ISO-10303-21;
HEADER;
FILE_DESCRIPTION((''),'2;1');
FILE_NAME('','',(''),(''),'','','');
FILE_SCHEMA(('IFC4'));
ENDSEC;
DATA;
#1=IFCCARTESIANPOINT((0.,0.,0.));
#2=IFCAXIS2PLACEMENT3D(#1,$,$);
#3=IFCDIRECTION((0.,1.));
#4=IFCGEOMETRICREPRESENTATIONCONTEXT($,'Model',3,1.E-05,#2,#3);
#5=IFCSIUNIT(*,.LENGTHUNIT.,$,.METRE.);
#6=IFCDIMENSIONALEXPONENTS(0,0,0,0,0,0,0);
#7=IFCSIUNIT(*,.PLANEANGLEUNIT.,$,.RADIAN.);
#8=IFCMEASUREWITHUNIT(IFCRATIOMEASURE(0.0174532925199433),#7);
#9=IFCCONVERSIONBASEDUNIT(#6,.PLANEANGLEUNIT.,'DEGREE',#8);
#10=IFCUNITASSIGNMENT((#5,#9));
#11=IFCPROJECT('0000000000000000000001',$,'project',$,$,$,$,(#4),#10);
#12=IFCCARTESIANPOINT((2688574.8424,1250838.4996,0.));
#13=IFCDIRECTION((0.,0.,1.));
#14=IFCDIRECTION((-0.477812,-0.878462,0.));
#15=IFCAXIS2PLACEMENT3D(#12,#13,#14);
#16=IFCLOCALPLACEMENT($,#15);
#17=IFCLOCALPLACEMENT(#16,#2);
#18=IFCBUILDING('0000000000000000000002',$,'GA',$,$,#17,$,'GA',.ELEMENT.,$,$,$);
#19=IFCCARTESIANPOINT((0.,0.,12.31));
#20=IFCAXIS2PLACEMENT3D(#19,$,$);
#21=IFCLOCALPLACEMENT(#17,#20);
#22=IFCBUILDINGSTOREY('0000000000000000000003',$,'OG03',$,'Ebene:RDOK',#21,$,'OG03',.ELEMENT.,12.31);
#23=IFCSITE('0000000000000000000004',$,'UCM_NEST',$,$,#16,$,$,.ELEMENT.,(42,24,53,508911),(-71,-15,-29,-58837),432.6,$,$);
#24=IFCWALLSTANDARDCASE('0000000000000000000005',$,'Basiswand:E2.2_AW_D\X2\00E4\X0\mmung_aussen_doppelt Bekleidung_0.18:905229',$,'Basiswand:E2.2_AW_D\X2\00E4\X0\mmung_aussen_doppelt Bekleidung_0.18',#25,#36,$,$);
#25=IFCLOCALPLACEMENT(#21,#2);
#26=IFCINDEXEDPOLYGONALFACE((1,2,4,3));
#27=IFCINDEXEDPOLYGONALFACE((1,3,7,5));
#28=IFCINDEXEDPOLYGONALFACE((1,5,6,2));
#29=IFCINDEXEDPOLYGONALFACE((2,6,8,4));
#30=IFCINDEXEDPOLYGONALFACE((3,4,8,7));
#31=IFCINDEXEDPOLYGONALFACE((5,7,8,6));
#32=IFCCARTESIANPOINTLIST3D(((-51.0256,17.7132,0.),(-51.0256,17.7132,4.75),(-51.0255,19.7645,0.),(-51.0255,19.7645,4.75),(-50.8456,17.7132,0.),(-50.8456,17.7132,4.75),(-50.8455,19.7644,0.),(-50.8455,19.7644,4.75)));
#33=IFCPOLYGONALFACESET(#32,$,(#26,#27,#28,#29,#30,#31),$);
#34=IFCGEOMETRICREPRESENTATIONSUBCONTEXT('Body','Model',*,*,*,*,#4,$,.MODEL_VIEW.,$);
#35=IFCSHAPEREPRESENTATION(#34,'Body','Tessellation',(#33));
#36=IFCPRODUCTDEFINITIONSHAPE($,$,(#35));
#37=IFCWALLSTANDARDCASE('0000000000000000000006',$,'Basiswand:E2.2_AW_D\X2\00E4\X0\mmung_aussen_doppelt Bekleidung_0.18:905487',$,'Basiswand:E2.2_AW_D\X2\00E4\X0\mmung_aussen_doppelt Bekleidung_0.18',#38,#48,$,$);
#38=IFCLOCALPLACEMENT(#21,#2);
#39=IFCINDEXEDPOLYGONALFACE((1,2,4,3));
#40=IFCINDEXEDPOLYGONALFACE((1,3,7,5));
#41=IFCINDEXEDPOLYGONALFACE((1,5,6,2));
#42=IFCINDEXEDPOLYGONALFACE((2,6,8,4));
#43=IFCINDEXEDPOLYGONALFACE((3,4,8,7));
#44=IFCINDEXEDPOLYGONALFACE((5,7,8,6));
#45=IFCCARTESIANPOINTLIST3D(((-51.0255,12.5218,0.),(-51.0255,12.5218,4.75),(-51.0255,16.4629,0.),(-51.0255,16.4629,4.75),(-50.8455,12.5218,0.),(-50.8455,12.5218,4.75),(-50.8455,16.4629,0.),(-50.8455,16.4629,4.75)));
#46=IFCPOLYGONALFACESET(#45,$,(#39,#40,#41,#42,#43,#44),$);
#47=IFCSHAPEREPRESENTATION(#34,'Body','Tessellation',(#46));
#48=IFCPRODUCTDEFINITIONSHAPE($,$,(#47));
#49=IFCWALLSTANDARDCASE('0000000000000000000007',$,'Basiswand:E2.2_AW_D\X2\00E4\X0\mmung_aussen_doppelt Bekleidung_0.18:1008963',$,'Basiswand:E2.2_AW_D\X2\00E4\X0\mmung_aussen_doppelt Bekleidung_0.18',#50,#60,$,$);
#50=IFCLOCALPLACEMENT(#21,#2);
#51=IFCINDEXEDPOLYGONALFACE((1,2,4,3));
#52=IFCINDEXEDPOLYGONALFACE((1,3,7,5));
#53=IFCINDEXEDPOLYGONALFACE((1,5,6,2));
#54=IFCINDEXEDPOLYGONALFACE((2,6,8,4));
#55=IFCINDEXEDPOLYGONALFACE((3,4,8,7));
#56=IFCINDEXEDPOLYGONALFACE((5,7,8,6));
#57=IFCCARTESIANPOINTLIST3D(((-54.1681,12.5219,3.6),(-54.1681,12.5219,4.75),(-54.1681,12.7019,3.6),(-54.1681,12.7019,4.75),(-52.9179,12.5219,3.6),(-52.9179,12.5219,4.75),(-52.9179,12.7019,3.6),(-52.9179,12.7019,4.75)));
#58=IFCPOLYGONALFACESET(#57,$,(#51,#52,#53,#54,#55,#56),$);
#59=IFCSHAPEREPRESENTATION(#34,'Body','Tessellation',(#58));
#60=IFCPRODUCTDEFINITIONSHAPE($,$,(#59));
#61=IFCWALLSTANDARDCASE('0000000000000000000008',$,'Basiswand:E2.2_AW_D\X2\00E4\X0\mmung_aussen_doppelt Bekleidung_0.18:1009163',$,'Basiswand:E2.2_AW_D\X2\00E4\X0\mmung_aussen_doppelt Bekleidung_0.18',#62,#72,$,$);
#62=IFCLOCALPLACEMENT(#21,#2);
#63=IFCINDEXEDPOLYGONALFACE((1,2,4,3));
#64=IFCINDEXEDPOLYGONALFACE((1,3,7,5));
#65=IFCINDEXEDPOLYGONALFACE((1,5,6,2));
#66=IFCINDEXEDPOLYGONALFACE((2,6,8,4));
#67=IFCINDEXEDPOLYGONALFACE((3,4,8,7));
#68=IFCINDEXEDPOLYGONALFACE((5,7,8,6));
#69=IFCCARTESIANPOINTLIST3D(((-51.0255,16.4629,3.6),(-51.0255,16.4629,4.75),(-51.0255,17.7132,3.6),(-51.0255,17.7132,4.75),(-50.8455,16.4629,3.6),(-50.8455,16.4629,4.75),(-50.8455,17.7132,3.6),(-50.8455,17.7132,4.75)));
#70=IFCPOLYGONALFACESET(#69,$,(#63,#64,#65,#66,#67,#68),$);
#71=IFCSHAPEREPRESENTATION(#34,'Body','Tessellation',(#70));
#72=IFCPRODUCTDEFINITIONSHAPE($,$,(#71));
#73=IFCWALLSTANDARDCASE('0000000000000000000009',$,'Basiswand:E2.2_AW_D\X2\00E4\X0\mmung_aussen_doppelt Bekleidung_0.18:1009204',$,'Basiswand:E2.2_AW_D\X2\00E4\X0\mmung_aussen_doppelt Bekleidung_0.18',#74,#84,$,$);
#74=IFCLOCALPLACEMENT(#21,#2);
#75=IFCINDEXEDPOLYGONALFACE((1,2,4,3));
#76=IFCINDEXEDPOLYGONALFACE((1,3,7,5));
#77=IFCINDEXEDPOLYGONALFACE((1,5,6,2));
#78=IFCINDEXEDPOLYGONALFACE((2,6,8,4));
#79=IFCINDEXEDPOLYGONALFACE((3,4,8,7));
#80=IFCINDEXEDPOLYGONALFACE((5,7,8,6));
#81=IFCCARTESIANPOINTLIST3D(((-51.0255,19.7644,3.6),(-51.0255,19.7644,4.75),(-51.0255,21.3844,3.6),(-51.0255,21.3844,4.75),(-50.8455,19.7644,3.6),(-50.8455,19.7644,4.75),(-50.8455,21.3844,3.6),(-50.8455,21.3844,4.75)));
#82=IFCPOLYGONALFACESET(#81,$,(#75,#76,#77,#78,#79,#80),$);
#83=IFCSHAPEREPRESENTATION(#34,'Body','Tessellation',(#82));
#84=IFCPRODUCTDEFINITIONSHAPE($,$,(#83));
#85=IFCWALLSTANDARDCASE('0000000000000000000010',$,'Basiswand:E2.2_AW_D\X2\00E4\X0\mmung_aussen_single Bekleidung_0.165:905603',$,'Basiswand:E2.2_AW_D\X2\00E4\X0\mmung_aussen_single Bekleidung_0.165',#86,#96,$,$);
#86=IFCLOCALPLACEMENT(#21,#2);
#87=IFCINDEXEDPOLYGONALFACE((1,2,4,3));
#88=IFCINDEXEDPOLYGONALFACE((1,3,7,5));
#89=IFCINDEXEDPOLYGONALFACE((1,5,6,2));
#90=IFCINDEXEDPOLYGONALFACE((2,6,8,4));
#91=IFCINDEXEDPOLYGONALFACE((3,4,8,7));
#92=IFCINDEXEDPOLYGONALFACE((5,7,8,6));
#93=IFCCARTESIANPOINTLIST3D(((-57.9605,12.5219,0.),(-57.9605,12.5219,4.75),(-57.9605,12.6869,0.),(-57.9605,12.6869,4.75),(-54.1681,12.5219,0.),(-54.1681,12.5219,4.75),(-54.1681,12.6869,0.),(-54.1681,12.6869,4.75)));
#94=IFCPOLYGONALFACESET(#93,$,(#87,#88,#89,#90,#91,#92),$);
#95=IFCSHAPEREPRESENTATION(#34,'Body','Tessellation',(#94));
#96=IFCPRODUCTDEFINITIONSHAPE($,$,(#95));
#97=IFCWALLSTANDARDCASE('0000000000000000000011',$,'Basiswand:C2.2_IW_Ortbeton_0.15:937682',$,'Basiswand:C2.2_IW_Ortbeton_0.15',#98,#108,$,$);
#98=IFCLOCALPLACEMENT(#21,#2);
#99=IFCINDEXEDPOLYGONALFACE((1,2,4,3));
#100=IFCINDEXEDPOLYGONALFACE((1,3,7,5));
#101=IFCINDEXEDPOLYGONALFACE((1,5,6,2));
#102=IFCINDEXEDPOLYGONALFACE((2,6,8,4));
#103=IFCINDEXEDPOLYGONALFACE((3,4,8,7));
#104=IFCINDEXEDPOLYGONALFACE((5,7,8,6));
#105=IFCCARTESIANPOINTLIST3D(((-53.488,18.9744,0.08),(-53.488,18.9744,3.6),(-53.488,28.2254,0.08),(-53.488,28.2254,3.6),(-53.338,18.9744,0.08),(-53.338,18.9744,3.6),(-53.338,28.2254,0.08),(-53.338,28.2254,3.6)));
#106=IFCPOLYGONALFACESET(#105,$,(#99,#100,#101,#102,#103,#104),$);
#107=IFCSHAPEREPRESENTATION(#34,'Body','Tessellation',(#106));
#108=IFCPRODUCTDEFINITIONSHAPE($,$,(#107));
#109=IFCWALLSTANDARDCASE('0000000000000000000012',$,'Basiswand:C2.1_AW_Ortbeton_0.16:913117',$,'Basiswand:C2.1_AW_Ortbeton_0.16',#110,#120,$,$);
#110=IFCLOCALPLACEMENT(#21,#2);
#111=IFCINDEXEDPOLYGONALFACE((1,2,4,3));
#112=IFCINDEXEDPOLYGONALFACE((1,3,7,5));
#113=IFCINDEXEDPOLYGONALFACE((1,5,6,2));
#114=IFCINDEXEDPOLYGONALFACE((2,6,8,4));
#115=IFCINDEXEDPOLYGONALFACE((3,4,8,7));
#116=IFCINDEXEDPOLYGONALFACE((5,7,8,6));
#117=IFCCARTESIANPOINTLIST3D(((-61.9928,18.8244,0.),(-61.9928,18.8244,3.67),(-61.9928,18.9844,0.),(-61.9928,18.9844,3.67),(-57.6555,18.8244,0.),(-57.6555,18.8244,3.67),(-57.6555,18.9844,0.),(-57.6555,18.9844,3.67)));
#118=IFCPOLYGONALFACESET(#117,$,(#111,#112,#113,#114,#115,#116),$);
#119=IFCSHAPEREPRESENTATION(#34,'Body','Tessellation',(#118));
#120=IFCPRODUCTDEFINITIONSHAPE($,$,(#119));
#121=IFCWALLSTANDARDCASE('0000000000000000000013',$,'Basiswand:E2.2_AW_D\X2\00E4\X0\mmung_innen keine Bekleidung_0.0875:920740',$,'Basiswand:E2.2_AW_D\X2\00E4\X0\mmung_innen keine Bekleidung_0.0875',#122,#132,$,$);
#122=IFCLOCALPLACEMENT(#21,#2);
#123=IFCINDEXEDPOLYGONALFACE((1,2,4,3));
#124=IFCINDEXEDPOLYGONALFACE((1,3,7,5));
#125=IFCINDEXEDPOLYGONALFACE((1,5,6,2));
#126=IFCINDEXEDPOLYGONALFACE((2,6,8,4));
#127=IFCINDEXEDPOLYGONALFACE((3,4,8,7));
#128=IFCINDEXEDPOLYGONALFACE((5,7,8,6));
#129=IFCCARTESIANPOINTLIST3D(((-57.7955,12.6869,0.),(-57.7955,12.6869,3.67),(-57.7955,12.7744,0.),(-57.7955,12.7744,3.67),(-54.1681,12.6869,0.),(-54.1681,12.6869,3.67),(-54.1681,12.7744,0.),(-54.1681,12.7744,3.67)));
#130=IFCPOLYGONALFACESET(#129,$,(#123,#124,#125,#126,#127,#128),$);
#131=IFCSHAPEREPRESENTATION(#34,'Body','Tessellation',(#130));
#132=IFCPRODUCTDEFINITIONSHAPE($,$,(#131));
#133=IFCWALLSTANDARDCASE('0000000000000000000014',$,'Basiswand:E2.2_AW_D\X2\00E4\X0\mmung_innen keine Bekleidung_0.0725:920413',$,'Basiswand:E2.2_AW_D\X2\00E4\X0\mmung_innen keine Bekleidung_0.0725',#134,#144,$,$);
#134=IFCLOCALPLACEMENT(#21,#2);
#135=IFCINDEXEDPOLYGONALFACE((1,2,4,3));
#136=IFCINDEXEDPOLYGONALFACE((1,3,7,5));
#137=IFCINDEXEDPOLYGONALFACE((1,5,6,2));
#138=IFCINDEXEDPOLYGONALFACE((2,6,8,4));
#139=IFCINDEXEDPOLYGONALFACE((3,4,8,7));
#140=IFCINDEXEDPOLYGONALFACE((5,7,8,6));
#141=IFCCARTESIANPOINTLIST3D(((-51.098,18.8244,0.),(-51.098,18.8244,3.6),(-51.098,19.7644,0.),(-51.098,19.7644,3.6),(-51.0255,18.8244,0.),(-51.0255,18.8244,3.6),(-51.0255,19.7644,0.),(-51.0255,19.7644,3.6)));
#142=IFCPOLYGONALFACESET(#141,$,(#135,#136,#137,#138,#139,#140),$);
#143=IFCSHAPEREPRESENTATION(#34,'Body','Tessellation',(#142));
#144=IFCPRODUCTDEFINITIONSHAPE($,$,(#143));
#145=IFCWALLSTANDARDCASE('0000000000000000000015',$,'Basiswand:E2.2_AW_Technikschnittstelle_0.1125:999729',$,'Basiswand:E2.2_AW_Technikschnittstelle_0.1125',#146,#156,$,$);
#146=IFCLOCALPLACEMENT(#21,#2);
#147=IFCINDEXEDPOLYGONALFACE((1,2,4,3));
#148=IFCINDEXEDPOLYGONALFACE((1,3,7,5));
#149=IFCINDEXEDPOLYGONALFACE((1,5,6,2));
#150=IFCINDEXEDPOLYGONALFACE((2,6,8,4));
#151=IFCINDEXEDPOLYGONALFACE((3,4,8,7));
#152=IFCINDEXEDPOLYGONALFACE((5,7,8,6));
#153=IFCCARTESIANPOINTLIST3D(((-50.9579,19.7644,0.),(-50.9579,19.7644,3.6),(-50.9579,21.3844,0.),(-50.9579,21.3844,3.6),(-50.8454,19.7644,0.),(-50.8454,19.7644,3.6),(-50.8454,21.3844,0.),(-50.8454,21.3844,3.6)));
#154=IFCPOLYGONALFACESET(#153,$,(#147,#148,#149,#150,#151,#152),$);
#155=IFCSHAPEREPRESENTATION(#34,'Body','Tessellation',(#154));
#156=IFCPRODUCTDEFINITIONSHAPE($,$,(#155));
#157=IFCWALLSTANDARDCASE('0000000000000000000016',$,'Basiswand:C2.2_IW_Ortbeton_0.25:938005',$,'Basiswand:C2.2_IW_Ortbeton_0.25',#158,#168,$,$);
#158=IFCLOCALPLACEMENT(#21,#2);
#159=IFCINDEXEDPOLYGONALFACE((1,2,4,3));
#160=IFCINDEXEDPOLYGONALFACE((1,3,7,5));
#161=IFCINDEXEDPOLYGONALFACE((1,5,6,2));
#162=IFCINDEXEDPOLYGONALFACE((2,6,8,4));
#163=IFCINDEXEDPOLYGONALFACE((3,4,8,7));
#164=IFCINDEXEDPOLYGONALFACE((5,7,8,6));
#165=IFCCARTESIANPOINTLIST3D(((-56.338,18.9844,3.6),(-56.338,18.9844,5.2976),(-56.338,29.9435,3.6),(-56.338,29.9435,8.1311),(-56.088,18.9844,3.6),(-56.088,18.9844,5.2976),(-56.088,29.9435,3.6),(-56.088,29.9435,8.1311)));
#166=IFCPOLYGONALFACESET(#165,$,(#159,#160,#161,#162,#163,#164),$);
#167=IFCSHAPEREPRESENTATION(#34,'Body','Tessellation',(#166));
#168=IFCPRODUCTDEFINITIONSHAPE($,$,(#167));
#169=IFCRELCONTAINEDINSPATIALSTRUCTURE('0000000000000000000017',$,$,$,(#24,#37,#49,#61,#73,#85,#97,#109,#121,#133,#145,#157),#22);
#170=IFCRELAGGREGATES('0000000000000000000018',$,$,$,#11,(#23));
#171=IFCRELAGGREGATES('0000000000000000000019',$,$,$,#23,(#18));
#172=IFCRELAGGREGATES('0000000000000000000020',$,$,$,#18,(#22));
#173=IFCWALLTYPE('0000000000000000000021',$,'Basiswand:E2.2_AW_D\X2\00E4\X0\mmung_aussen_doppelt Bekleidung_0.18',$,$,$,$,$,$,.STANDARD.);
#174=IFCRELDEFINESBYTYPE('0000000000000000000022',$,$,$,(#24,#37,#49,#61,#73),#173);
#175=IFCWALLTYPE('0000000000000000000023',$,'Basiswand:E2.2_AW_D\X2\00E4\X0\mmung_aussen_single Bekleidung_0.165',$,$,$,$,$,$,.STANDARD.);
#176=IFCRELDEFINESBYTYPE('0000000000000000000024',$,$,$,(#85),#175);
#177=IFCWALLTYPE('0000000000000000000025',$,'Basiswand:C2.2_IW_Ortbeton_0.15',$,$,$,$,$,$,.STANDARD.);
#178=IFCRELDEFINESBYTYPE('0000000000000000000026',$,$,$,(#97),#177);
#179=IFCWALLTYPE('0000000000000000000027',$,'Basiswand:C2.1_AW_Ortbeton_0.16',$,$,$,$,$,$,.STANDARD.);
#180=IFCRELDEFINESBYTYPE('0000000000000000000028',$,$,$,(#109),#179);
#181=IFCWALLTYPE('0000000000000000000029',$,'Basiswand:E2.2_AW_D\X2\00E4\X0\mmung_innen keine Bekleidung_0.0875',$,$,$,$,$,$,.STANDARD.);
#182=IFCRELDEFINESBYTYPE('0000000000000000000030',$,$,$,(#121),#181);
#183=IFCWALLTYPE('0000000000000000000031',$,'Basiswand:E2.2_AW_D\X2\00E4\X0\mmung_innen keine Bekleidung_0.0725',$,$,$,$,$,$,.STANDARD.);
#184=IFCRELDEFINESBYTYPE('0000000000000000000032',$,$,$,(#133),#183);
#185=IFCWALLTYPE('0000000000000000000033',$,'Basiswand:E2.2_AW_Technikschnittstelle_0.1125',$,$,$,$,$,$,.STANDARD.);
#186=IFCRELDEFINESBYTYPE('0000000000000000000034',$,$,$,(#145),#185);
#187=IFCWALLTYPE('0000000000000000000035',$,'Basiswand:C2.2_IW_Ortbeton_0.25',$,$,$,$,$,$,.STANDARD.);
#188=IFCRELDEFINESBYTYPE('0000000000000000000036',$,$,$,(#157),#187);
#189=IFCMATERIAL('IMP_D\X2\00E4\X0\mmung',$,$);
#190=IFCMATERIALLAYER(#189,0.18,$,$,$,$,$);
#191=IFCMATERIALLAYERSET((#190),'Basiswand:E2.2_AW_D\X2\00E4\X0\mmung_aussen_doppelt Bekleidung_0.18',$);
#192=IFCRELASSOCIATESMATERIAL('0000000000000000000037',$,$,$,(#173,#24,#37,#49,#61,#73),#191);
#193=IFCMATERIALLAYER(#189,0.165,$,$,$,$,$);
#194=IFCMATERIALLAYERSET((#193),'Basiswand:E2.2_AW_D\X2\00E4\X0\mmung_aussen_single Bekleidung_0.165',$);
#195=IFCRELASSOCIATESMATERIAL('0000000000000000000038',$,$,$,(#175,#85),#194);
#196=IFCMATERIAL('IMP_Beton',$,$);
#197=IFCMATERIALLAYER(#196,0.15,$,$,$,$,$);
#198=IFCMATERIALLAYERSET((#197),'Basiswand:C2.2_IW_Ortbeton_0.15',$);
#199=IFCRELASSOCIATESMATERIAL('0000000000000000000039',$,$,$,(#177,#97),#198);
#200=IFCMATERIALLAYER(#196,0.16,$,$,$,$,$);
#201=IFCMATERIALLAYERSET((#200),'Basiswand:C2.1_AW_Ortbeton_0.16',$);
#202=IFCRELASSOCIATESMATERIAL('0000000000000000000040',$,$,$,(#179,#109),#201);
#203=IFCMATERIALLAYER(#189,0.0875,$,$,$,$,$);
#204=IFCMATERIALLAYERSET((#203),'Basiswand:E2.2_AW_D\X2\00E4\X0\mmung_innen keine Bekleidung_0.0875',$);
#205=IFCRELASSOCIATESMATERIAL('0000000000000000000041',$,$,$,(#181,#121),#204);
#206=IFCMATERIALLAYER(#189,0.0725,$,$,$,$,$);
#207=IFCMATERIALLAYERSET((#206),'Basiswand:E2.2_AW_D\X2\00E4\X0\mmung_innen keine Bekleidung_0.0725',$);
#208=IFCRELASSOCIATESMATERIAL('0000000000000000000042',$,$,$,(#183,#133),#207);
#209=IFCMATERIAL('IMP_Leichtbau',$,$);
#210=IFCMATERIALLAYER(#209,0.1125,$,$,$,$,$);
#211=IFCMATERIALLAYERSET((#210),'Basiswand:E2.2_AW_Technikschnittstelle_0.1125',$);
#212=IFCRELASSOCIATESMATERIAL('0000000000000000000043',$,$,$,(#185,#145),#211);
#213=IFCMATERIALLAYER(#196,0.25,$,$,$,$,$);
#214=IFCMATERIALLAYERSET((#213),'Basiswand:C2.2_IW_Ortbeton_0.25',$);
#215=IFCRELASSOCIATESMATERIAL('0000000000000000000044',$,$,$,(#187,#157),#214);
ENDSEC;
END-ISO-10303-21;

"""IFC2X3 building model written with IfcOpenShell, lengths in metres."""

from ifc_helpers import new_model, entity, si_unit, converted_unit, direction, frame, frame_2d, origin, place, context, subcontext, project, spatial, polyline, rectangle, extrude, clip, halfspace, bounded_halfspace, material, layer, layer_set, layer_usage, type_object, element, save


model = new_model("IFC2X3")

# Units and contexts
model_context = context("Model", 3, precision=1e-05, world=origin(), true_north=direction((0.0, 1.0)))
body_context = subcontext(model_context, "Body", "Model", "MODEL_VIEW")
ifc_project = project(units=[si_unit("LENGTHUNIT", "METRE"), converted_unit("PLANEANGLEUNIT", "DEGREE", entity("IfcRatioMeasure", 0.0174532925199433), si_unit("PLANEANGLEUNIT", "RADIAN"), dimensions=[0, 0, 0, 0, 0, 0, 0])], contexts=[model_context])

# Site, building, storey
site_placement = place(None, frame((2688574.8424, 1250838.4996, 0.0), z_axis=(0.0, 0.0, 1.0), x_axis=(-0.477812, -0.878462, 0.0)))
site = spatial("IfcSite", under=ifc_project, at=site_placement, Name="UCM_NEST", CompositionType="ELEMENT", RefLatitude=(42, 24, 53, 508911), RefLongitude=(-71, -15, -29, -58837), RefElevation=432.6)
building_placement = place(site_placement, origin())
building = spatial("IfcBuilding", under=site, at=building_placement, Name="GA", LongName="GA", CompositionType="ELEMENT")
storey_placement = place(building_placement, frame((0.0, 0.0, 12.31)))
storey = spatial("IfcBuildingStorey", under=building, at=storey_placement, Name="OG03", ObjectType="Ebene:RDOK", LongName="OG03", CompositionType="ELEMENT", Elevation=12.31)

# Walls
ifc_material_1 = material(Name="IMP_Dämmung")
ifc_layer_1 = layer(ifc_material_1, 0.18)
ifc_layer_set_1 = layer_set([ifc_layer_1], Name="Basiswand:E2.2_AW_Dämmung_aussen_doppelt Bekleidung_0.18")
ifc_layer_usage_1 = layer_usage(ifc_layer_set_1, "AXIS2", "NEGATIVE", 0.09)
wall_type_1 = type_object("IfcWallType", Name="Basiswand:E2.2_AW_Dämmung_aussen_doppelt Bekleidung_0.18", PredefinedType="STANDARD", material=ifc_layer_set_1)
wall_1_placement = place(storey_placement, frame((-50.9355, 19.7644, 0.0), z_axis=(0.0, 0.0, 1.0), x_axis=(-0.000045, -1.0, 0.0)))
element("IfcWallStandardCase", 1, at=wall_1_placement, inside=storey, type_object=wall_type_1, material=ifc_layer_usage_1, Name="Basiswand:E2.2_AW_Dämmung_aussen_doppelt Bekleidung_0.18:905229", ObjectType="Basiswand:E2.2_AW_Dämmung_aussen_doppelt Bekleidung_0.18", context=body_context, shape_type="SweptSolid", body=[
    extrude(rectangle(XDim=2.0513, YDim=0.18, at=frame_2d((1.0256, 0.0), x_axis=(-1.0, 0.0))), origin(), (0.0, 0.0, 1.0), 4.75),
])
ifc_layer_usage_2 = layer_usage(ifc_layer_set_1, "AXIS2", "NEGATIVE", 0.09)
wall_2_placement = place(storey_placement, frame((-50.9355, 16.4629, 0.0), z_axis=(0.0, 0.0, 1.0), x_axis=(0.0, -1.0, 0.0)))
element("IfcWallStandardCase", 2, at=wall_2_placement, inside=storey, type_object=wall_type_1, material=ifc_layer_usage_2, Name="Basiswand:E2.2_AW_Dämmung_aussen_doppelt Bekleidung_0.18:905487", ObjectType="Basiswand:E2.2_AW_Dämmung_aussen_doppelt Bekleidung_0.18", context=body_context, shape_type="SweptSolid", body=[
    extrude(rectangle(XDim=3.9411, YDim=0.18, at=frame_2d((1.9706, 0.0), x_axis=(-1.0, 0.0))), origin(), (0.0, 0.0, 1.0), 4.75),
])
ifc_layer_usage_3 = layer_usage(ifc_layer_set_1, "AXIS2", "NEGATIVE", 0.09)
wall_3_placement = place(storey_placement, frame((-54.1681, 12.6119, 3.6)))
element("IfcWallStandardCase", 3, at=wall_3_placement, inside=storey, type_object=wall_type_1, material=ifc_layer_usage_3, Name="Basiswand:E2.2_AW_Dämmung_aussen_doppelt Bekleidung_0.18:1008963", ObjectType="Basiswand:E2.2_AW_Dämmung_aussen_doppelt Bekleidung_0.18", context=body_context, shape_type="SweptSolid", body=[
    extrude(rectangle(XDim=1.2503, YDim=0.18, at=frame_2d((0.6251, 0.0), x_axis=(-1.0, 0.0))), origin(), (0.0, 0.0, 1.0), 1.15),
])
ifc_layer_usage_4 = layer_usage(ifc_layer_set_1, "AXIS2", "NEGATIVE", 0.09)
wall_4_placement = place(storey_placement, frame((-50.9355, 16.4629, 3.6), z_axis=(0.0, 0.0, 1.0), x_axis=(0.0, 1.0, 0.0)))
element("IfcWallStandardCase", 4, at=wall_4_placement, inside=storey, type_object=wall_type_1, material=ifc_layer_usage_4, Name="Basiswand:E2.2_AW_Dämmung_aussen_doppelt Bekleidung_0.18:1009163", ObjectType="Basiswand:E2.2_AW_Dämmung_aussen_doppelt Bekleidung_0.18", context=body_context, shape_type="SweptSolid", body=[
    extrude(rectangle(XDim=1.2503, YDim=0.18, at=frame_2d((0.6251, 0.0), x_axis=(-1.0, 0.0))), origin(), (0.0, 0.0, 1.0), 1.15),
])
ifc_layer_usage_5 = layer_usage(ifc_layer_set_1, "AXIS2", "NEGATIVE", 0.09)
wall_5_placement = place(storey_placement, frame((-50.9355, 19.7644, 3.6), z_axis=(0.0, 0.0, 1.0), x_axis=(0.0, 1.0, 0.0)))
element("IfcWallStandardCase", 5, at=wall_5_placement, inside=storey, type_object=wall_type_1, material=ifc_layer_usage_5, Name="Basiswand:E2.2_AW_Dämmung_aussen_doppelt Bekleidung_0.18:1009204", ObjectType="Basiswand:E2.2_AW_Dämmung_aussen_doppelt Bekleidung_0.18", context=body_context, shape_type="SweptSolid", body=[
    extrude(rectangle(XDim=1.62, YDim=0.18, at=frame_2d((0.81, 0.0), x_axis=(-1.0, 0.0))), origin(), (0.0, 0.0, 1.0), 1.15),
])
ifc_layer_2 = layer(ifc_material_1, 0.165)
ifc_layer_set_2 = layer_set([ifc_layer_2], Name="Basiswand:E2.2_AW_Dämmung_aussen_single Bekleidung_0.165")
ifc_layer_usage_6 = layer_usage(ifc_layer_set_2, "AXIS2", "NEGATIVE", 0.0825)
wall_type_2 = type_object("IfcWallType", Name="Basiswand:E2.2_AW_Dämmung_aussen_single Bekleidung_0.165", PredefinedType="STANDARD", material=ifc_layer_set_2)
wall_6_placement = place(storey_placement, frame((-54.1681, 12.6044, 0.0), z_axis=(0.0, 0.0, 1.0), x_axis=(-1.0, 0.0, 0.0)))
element("IfcWallStandardCase", 6, at=wall_6_placement, inside=storey, type_object=wall_type_2, material=ifc_layer_usage_6, Name="Basiswand:E2.2_AW_Dämmung_aussen_single Bekleidung_0.165:905603", ObjectType="Basiswand:E2.2_AW_Dämmung_aussen_single Bekleidung_0.165", context=body_context, shape_type="SweptSolid", body=[
    extrude(rectangle(XDim=3.7923, YDim=0.165, at=frame_2d((1.8962, 0.0), x_axis=(-1.0, 0.0))), origin(), (0.0, 0.0, 1.0), 4.75),
])

# Shared definitions
ifc_material_2 = material(Name="IMP_Beton")
ifc_layer_3 = layer(ifc_material_2, 0.15)
ifc_layer_set_3 = layer_set([ifc_layer_3], Name="Basiswand:C2.2_IW_Ortbeton_0.15")
wall_type_3 = type_object("IfcWallType", Name="Basiswand:C2.2_IW_Ortbeton_0.15", PredefinedType="STANDARD", material=ifc_layer_set_3)

# Wall
ifc_layer_usage_7 = layer_usage(ifc_layer_set_3, "AXIS2", "NEGATIVE", 0.075)
wall_7_placement = place(storey_placement, frame((-53.413, 18.9744, 0.08), z_axis=(0.0, 0.0, 1.0), x_axis=(0.0, 1.0, 0.0)))
element("IfcWallStandardCase", 7, at=wall_7_placement, inside=storey, type_object=wall_type_3, material=ifc_layer_usage_7, Name="Basiswand:C2.2_IW_Ortbeton_0.15:937682", ObjectType="Basiswand:C2.2_IW_Ortbeton_0.15", context=body_context, shape_type="Clipping", body=[
    clip(extrude(rectangle(XDim=9.251, YDim=0.15, at=frame_2d((4.6255, 0.0), x_axis=(-1.0, 0.0))), origin(), (0.0, 0.0, 1.0), 3.52), bounded_halfspace(frame((9.251, -0.075, 0.0), z_axis=(0.0, 0.0, 1.0), x_axis=(0.0, 1.0, 0.0)), True, frame((9.251, -0.075, 0.0), z_axis=(0.0, 0.0, 1.0), x_axis=(0.0, 1.0, 0.0)), polyline([(0.0, 0.0), (0.15, 0.0), (0.15, 9.251), (0.0, 9.251), (0.0, 0.151), (0.0, 0.15), (0.0, 0.0)]))),
])

# Walls
ifc_layer_4 = layer(ifc_material_2, 0.16)
ifc_layer_set_4 = layer_set([ifc_layer_4], Name="Basiswand:C2.1_AW_Ortbeton_0.16")
ifc_layer_usage_8 = layer_usage(ifc_layer_set_4, "AXIS2", "NEGATIVE", 0.08)
wall_type_4 = type_object("IfcWallType", Name="Basiswand:C2.1_AW_Ortbeton_0.16", PredefinedType="STANDARD", material=ifc_layer_set_4)
wall_8_placement = place(storey_placement, frame((-57.6555, 18.9044, 0.0), z_axis=(0.0, 0.0, 1.0), x_axis=(-1.0, 0.0, 0.0)))
element("IfcWallStandardCase", 8, at=wall_8_placement, inside=storey, type_object=wall_type_4, material=ifc_layer_usage_8, Name="Basiswand:C2.1_AW_Ortbeton_0.16:913117", ObjectType="Basiswand:C2.1_AW_Ortbeton_0.16", context=body_context, shape_type="SweptSolid", body=[
    extrude(rectangle(XDim=4.3373, YDim=0.16, at=frame_2d((2.1686, 0.0), x_axis=(-1.0, 0.0))), origin(), (0.0, 0.0, 1.0), 3.67),
])
ifc_layer_5 = layer(ifc_material_1, 0.0875)
ifc_layer_set_5 = layer_set([ifc_layer_5], Name="Basiswand:E2.2_AW_Dämmung_innen keine Bekleidung_0.0875")
ifc_layer_usage_9 = layer_usage(ifc_layer_set_5, "AXIS2", "NEGATIVE", 0.0437)
wall_type_5 = type_object("IfcWallType", Name="Basiswand:E2.2_AW_Dämmung_innen keine Bekleidung_0.0875", PredefinedType="STANDARD", material=ifc_layer_set_5)
wall_9_placement = place(storey_placement, frame((-54.1681, 12.7307, 0.0), z_axis=(0.0, 0.0, 1.0), x_axis=(-1.0, 0.0, 0.0)))
element("IfcWallStandardCase", 9, at=wall_9_placement, inside=storey, type_object=wall_type_5, material=ifc_layer_usage_9, Name="Basiswand:E2.2_AW_Dämmung_innen keine Bekleidung_0.0875:920740", ObjectType="Basiswand:E2.2_AW_Dämmung_innen keine Bekleidung_0.0875", context=body_context, shape_type="SweptSolid", body=[
    extrude(rectangle(XDim=3.6273, YDim=0.0875, at=frame_2d((1.8137, 0.0), x_axis=(-1.0, 0.0))), origin(), (0.0, 0.0, 1.0), 3.67),
])
ifc_layer_6 = layer(ifc_material_1, 0.0725)
ifc_layer_set_6 = layer_set([ifc_layer_6], Name="Basiswand:E2.2_AW_Dämmung_innen keine Bekleidung_0.0725")
ifc_layer_usage_10 = layer_usage(ifc_layer_set_6, "AXIS2", "NEGATIVE", 0.0362)
wall_type_6 = type_object("IfcWallType", Name="Basiswand:E2.2_AW_Dämmung_innen keine Bekleidung_0.0725", PredefinedType="STANDARD", material=ifc_layer_set_6)
wall_10_placement = place(storey_placement, frame((-51.0617, 19.7644, 0.0), z_axis=(0.0, 0.0, 1.0), x_axis=(0.0, -1.0, 0.0)))
element("IfcWallStandardCase", 10, at=wall_10_placement, inside=storey, type_object=wall_type_6, material=ifc_layer_usage_10, Name="Basiswand:E2.2_AW_Dämmung_innen keine Bekleidung_0.0725:920413", ObjectType="Basiswand:E2.2_AW_Dämmung_innen keine Bekleidung_0.0725", context=body_context, shape_type="SweptSolid", body=[
    extrude(rectangle(XDim=0.94, YDim=0.0725, at=frame_2d((0.47, 0.0), x_axis=(-1.0, 0.0))), origin(), (0.0, 0.0, 1.0), 3.6),
])
ifc_material_3 = material(Name="IMP_Leichtbau")
ifc_layer_7 = layer(ifc_material_3, 0.1125)
ifc_layer_set_7 = layer_set([ifc_layer_7], Name="Basiswand:E2.2_AW_Technikschnittstelle_0.1125")
ifc_layer_usage_11 = layer_usage(ifc_layer_set_7, "AXIS2", "NEGATIVE", 0.0563)
wall_type_7 = type_object("IfcWallType", Name="Basiswand:E2.2_AW_Technikschnittstelle_0.1125", PredefinedType="STANDARD", material=ifc_layer_set_7)
wall_11_placement = place(storey_placement, frame((-50.9017, 19.7644, 0.0), z_axis=(0.0, 0.0, 1.0), x_axis=(0.0, 1.0, 0.0)))
element("IfcWallStandardCase", 11, at=wall_11_placement, inside=storey, type_object=wall_type_7, material=ifc_layer_usage_11, Name="Basiswand:E2.2_AW_Technikschnittstelle_0.1125:999729", ObjectType="Basiswand:E2.2_AW_Technikschnittstelle_0.1125", context=body_context, shape_type="SweptSolid", body=[
    extrude(rectangle(XDim=1.62, YDim=0.1125, at=frame_2d((0.81, 0.0), x_axis=(-1.0, 0.0))), origin(), (0.0, 0.0, 1.0), 3.6),
])
ifc_layer_8 = layer(ifc_material_2, 0.25)
ifc_layer_set_8 = layer_set([ifc_layer_8], Name="Basiswand:C2.2_IW_Ortbeton_0.25")
ifc_layer_usage_12 = layer_usage(ifc_layer_set_8, "AXIS2", "NEGATIVE", 0.125)
wall_type_8 = type_object("IfcWallType", Name="Basiswand:C2.2_IW_Ortbeton_0.25", PredefinedType="STANDARD", material=ifc_layer_set_8)
wall_12_placement = place(storey_placement, frame((-56.213, 18.9844, 3.6), z_axis=(0.0, 0.0, 1.0), x_axis=(0.0, 1.0, 0.0)))
element("IfcWallStandardCase", 12, at=wall_12_placement, inside=storey, type_object=wall_type_8, material=ifc_layer_usage_12, Name="Basiswand:C2.2_IW_Ortbeton_0.25:938005", ObjectType="Basiswand:C2.2_IW_Ortbeton_0.25", context=body_context, shape_type="Clipping", body=[
    clip(extrude(rectangle(XDim=10.959, YDim=0.25, at=frame_2d((5.4795, 0.0), x_axis=(-1.0, 0.0))), origin(), (0.0, 0.0, 1.0), 4.5311), halfspace(frame((0.0, -0.125, 1.6976), z_axis=(-0.250322, 0.0, 0.968163), x_axis=(0.0, 1.0, 0.0)), False)),
])

save(model, "model.ifc")
